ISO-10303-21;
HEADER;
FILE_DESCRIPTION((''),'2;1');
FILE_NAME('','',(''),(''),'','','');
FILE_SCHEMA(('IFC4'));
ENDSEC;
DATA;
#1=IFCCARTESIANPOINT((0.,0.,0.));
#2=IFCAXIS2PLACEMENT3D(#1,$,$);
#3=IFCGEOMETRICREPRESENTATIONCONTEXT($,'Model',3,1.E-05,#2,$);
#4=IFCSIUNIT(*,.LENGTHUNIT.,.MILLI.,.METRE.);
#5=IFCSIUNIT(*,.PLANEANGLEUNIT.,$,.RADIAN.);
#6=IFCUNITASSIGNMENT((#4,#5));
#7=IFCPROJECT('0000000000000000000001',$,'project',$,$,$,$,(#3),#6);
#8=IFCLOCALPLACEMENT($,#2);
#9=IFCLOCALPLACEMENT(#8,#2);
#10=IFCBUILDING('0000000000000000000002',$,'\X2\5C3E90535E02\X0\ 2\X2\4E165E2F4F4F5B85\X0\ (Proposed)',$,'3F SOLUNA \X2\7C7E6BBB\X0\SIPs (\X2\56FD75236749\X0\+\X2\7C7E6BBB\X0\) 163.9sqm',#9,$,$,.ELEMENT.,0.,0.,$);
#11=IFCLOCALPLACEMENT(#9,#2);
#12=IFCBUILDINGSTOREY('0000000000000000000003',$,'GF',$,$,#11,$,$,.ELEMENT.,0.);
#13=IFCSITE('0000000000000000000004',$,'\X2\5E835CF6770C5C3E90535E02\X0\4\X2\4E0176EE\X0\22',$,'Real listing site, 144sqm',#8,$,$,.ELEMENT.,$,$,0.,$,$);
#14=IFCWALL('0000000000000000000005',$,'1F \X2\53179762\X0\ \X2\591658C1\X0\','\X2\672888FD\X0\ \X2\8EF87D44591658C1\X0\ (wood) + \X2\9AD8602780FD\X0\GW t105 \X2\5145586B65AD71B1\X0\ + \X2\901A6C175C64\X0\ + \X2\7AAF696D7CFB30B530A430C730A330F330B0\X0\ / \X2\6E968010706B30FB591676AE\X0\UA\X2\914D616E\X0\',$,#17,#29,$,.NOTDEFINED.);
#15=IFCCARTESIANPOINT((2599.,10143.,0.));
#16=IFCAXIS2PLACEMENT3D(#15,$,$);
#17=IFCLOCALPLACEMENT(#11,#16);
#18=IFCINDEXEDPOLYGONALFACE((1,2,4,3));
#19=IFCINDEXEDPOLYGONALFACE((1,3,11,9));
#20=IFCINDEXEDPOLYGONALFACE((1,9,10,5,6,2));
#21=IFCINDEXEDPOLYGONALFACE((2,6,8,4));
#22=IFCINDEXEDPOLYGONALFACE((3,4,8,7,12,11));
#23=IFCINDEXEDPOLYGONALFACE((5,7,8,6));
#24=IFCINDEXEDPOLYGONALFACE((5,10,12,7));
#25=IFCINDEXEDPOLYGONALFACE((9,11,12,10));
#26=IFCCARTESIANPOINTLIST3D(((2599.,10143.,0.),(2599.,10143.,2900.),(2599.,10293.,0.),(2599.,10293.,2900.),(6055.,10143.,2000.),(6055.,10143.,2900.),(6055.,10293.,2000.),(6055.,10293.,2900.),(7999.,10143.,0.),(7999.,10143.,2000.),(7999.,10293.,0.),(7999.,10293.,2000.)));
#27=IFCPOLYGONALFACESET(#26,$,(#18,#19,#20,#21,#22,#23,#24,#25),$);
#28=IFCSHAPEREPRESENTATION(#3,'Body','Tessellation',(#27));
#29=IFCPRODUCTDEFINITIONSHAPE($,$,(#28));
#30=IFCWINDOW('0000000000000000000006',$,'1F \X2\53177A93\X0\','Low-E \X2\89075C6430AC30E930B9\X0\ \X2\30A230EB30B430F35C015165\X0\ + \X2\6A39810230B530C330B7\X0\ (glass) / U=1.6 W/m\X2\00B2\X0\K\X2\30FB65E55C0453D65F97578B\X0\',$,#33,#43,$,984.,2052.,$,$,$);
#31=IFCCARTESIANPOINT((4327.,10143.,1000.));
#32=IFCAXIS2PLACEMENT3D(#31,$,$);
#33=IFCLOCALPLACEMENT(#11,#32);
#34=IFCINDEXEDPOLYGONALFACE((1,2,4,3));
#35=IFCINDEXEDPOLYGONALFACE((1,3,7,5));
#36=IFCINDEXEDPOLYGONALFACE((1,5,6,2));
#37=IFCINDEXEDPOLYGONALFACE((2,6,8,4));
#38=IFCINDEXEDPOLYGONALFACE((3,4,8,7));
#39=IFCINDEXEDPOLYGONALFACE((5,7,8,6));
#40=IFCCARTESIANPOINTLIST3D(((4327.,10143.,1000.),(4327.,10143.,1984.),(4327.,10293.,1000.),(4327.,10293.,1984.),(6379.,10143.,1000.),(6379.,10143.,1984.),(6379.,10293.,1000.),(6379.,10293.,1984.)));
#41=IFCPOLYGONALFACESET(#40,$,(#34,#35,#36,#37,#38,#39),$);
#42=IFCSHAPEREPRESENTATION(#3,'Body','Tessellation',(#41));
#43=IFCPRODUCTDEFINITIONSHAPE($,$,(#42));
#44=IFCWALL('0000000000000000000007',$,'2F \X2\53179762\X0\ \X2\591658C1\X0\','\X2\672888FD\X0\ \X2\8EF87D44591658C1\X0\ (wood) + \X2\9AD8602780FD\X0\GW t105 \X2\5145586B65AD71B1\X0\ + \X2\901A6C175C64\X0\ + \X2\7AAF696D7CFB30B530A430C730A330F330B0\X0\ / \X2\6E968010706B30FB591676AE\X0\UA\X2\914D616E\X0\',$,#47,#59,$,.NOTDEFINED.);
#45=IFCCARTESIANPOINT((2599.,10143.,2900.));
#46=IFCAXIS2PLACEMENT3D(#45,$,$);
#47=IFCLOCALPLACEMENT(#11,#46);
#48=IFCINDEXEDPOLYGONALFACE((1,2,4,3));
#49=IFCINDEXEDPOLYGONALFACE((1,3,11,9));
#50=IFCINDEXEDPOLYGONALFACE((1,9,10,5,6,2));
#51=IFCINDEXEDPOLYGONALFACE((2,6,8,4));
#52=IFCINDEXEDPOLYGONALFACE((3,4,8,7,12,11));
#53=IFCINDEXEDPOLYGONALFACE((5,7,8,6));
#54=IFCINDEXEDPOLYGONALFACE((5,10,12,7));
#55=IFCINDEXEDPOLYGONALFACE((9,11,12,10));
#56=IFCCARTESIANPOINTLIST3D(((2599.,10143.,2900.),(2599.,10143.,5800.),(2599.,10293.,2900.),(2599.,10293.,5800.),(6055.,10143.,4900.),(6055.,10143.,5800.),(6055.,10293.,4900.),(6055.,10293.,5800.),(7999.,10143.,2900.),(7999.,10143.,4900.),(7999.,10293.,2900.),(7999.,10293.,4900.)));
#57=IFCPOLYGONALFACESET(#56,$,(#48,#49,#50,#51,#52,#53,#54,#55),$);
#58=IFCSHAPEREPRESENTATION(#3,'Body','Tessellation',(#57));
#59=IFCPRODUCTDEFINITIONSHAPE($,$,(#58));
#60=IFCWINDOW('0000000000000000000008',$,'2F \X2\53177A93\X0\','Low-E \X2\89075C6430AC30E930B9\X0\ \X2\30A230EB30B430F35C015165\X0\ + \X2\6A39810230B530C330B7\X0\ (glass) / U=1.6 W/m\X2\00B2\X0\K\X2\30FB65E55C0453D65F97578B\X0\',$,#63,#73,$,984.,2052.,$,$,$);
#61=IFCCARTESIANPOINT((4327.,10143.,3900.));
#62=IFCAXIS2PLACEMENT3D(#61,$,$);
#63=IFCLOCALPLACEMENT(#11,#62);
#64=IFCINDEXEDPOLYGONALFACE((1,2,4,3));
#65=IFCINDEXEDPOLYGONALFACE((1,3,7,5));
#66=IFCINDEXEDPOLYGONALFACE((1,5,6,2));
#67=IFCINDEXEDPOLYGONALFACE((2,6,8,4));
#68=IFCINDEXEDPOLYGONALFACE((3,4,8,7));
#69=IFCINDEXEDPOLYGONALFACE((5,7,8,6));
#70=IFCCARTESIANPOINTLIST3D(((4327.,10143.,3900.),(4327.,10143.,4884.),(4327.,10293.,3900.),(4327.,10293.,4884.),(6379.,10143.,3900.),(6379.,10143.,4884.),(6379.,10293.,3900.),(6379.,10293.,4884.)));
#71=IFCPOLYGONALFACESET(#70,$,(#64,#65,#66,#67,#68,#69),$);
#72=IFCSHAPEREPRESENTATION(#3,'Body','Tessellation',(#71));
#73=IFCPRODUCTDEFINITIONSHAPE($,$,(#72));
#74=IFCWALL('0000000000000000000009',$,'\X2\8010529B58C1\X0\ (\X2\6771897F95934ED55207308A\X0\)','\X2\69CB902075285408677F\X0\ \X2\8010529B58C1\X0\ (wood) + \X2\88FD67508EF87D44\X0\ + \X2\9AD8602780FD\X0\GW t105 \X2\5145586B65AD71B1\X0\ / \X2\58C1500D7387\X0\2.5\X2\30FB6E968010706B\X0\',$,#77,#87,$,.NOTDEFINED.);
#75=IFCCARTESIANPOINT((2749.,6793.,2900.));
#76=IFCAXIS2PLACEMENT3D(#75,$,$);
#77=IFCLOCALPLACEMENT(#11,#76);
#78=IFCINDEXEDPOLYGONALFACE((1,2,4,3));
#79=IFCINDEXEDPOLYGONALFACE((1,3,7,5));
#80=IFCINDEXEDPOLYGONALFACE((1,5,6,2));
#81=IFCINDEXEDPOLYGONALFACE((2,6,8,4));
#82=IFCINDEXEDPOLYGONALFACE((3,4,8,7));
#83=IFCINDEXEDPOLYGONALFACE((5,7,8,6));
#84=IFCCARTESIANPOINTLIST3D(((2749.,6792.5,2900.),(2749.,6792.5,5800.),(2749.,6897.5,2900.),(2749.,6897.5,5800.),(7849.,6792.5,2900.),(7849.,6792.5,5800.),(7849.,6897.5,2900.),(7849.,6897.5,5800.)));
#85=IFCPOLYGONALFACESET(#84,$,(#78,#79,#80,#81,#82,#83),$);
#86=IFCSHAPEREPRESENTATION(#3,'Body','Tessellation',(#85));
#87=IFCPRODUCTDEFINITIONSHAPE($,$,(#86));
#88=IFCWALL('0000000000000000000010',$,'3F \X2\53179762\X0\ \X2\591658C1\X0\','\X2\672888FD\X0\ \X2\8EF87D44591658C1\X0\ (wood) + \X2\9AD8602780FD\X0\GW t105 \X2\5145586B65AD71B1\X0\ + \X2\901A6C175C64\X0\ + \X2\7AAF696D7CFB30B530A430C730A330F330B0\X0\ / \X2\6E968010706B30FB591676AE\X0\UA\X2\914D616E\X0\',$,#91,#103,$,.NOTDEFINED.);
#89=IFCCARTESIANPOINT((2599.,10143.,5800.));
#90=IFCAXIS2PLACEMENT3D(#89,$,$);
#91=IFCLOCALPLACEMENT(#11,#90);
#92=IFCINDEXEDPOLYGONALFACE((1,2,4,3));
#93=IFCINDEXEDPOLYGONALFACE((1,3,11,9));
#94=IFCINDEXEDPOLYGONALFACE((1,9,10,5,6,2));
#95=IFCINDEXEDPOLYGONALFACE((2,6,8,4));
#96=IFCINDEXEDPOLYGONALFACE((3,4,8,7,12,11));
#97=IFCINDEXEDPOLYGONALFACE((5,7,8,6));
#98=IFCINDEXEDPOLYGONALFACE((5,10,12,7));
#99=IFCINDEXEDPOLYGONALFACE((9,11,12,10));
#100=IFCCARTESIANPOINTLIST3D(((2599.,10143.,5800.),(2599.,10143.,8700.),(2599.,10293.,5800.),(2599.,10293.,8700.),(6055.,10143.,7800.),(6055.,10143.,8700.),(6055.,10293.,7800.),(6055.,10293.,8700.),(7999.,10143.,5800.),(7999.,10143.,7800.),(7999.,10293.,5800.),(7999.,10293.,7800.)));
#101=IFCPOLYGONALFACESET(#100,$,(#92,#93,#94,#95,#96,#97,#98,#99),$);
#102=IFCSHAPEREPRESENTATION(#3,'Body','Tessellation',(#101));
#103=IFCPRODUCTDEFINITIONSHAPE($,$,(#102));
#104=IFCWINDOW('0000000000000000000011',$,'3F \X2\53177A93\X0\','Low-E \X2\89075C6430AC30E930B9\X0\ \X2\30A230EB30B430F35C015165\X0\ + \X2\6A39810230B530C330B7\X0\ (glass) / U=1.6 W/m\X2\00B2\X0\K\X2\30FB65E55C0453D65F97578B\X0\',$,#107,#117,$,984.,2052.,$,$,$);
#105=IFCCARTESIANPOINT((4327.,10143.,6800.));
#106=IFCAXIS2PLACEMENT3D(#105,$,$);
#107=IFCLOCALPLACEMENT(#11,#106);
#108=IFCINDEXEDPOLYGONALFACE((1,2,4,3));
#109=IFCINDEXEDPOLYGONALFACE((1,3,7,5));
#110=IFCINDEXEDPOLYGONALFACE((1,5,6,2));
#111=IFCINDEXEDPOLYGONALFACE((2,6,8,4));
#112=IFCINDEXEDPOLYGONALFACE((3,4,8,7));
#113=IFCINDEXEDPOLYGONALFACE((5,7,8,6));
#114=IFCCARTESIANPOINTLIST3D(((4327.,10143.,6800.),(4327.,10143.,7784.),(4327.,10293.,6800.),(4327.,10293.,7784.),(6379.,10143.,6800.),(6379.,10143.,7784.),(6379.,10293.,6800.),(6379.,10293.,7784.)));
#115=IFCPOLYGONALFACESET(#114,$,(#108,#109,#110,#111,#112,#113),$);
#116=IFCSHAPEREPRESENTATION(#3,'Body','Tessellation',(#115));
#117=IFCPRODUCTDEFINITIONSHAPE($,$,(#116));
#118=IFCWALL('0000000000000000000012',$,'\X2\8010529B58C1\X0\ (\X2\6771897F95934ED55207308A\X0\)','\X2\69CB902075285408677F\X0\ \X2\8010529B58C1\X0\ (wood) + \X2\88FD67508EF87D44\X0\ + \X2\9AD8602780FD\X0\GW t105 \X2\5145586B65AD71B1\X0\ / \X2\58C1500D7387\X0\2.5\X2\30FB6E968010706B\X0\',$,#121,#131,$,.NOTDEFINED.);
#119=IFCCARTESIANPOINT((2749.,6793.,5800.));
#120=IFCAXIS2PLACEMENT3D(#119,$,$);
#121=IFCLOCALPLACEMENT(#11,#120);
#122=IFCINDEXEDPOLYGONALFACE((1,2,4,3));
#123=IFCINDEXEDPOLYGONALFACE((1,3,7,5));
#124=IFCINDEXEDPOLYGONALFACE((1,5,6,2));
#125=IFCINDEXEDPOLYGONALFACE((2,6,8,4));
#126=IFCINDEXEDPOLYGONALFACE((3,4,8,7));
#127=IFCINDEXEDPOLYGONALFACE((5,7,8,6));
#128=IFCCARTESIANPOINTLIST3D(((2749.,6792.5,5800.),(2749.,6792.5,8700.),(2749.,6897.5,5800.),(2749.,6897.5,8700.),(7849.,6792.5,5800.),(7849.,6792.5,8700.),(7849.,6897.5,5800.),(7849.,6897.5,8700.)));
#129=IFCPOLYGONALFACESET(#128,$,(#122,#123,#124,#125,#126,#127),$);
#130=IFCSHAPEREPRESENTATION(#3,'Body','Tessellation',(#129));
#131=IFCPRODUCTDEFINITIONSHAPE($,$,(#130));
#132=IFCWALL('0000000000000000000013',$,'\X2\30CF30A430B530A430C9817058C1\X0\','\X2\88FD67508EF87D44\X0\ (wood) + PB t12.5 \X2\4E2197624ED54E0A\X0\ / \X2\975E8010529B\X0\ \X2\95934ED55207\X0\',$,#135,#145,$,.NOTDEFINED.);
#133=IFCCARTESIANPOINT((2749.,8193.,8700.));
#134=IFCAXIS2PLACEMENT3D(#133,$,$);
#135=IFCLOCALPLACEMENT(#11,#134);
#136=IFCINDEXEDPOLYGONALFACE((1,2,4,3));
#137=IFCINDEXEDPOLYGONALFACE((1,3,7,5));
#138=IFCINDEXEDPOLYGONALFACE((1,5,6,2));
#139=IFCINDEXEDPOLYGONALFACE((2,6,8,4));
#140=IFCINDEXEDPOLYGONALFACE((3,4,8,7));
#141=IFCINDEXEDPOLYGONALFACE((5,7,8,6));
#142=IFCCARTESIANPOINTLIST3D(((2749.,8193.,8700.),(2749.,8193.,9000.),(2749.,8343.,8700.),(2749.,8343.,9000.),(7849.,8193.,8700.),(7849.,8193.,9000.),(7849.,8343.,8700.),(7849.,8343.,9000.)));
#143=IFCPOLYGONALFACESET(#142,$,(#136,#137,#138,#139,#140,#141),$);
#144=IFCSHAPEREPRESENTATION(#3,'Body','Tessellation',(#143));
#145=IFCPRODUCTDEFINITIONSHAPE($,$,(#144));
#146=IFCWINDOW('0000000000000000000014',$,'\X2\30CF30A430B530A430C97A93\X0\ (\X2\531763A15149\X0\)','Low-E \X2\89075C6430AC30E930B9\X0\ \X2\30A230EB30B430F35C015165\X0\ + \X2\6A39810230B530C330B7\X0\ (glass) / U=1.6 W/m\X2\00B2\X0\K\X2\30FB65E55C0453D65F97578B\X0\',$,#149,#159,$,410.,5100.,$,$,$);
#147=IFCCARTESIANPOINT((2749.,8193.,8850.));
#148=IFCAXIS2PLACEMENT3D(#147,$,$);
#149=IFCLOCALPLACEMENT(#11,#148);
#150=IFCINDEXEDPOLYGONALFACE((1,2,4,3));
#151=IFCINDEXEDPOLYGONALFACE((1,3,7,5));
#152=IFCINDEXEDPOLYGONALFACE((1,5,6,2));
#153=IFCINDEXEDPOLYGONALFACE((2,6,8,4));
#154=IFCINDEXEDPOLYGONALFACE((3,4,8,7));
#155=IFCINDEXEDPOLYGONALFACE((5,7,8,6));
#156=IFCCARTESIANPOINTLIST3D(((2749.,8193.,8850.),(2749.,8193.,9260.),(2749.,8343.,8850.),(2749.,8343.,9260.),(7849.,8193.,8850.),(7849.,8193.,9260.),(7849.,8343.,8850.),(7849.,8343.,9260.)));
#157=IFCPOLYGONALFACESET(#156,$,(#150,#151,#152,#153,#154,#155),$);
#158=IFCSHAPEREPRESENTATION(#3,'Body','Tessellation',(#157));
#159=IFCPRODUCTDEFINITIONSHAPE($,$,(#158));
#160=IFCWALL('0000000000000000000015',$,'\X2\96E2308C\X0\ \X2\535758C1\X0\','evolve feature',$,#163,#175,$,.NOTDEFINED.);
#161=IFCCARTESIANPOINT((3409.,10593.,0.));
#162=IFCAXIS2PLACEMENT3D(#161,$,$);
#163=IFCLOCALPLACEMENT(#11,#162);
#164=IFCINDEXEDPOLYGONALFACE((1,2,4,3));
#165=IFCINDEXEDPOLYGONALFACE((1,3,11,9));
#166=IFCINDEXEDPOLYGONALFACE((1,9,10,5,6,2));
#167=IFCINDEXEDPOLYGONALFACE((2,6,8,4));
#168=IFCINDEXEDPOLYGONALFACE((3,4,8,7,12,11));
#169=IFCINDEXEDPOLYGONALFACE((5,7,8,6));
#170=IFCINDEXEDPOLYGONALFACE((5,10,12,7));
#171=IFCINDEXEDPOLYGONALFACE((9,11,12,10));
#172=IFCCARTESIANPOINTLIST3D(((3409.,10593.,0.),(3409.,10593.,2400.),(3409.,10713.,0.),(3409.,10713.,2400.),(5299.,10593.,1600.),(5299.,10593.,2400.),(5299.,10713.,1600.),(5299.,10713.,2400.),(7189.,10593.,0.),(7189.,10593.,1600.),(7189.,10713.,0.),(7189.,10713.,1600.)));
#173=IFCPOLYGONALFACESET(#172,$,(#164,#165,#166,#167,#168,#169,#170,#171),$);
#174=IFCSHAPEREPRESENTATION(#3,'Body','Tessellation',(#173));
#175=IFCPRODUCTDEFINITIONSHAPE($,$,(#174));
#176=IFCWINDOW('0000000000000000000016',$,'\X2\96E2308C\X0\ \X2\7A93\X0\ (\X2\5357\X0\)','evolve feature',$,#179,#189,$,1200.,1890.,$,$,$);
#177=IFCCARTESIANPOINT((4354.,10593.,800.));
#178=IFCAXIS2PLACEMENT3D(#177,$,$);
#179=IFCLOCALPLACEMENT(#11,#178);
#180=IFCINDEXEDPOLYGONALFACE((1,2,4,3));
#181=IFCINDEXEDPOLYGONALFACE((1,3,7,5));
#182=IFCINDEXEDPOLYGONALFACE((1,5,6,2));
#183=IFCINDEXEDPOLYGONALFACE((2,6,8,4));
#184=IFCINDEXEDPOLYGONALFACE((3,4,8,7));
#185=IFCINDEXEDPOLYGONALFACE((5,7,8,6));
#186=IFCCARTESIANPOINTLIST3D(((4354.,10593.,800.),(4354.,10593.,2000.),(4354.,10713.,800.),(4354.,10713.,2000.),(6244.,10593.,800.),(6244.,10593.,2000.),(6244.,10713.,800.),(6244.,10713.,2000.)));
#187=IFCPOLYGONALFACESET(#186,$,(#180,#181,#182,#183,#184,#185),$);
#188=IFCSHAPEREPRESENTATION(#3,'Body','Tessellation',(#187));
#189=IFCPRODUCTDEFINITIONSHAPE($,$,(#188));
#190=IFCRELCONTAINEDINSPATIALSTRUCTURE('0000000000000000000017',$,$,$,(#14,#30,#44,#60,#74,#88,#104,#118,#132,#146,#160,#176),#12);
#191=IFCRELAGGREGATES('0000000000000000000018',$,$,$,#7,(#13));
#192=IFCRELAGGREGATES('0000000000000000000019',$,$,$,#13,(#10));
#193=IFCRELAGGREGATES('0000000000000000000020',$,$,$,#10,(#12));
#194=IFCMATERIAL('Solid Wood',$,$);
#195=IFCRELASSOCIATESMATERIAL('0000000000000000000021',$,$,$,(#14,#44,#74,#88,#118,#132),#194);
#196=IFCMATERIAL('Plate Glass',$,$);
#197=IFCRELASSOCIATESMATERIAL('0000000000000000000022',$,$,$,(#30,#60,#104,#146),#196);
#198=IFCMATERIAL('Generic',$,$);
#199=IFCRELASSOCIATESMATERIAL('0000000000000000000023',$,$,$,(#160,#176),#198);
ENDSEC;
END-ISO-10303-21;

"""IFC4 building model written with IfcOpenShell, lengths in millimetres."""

from ifc_helpers import new_model, si_unit, frame, frame_2d, origin, place, context, project, spatial, rectangle, extrude, material, element, fill, save


model = new_model("IFC4")

# Units and contexts
model_context = context("Model", 3, precision=1e-05, world=origin())
ifc_project = project(units=[si_unit("LENGTHUNIT", "METRE", prefix="MILLI"), si_unit("PLANEANGLEUNIT", "RADIAN")], contexts=[model_context])

# Site, building, storey
site_placement = place(None, origin())
site = spatial("IfcSite", under=ifc_project, at=site_placement, Name="広島県尾道市4丁目22", ObjectType="Real listing site, 144sqm", CompositionType="ELEMENT", RefElevation=0.0)
building_placement = place(site_placement, origin())
building = spatial("IfcBuilding", under=site, at=building_placement, Name="尾道市 2世帯住宅 (Proposed)", ObjectType="3F SOLUNA 籾殻SIPs (国産杉+籾殻) 163.9sqm", CompositionType="ELEMENT", ElevationOfRefHeight=0.0, ElevationOfTerrain=0.0)
storey_placement = place(building_placement, origin())
storey = spatial("IfcBuildingStorey", under=building, at=storey_placement, Name="GF", CompositionType="ELEMENT", Elevation=0.0)

# Shared definitions
ifc_material_1 = material(Name="Generic")

# Wall, opening, window
ifc_material_2 = material(Name="Solid Wood")
wall_1_placement = place(storey_placement, frame((2599.0, 10143.0, 0.0)))
wall_1 = element("IfcWall", 1, at=wall_1_placement, inside=storey, material=ifc_material_2, Name="1F 北面 外壁", Description="木製 軸組外壁 (wood) + 高性能GW t105 充填断熱 + 通気層 + 窯業系サイディング / 準耐火・外皮UA配慮", PredefinedType="NOTDEFINED", context=model_context, shape_type="SweptSolid", body=[
    extrude(rectangle(XDim=5400.0, YDim=150.0, at=frame_2d((2700.0, 75.0))), frame((2599.0, 10143.0, 0.0)), (0.0, 0.0, 1.0), 2900.0),
])
opening_1_placement = place(storey_placement, frame((4327.0, 10143.0, 1000.0)))
opening_1 = element("IfcOpeningElement", 2, at=opening_1_placement, cuts=wall_1, PredefinedType="NOTDEFINED", context=model_context, shape_type="SweptSolid", body=[
    extrude(rectangle(XDim=2052.0, YDim=150.0, at=frame_2d((1026.0, 75.0))), frame((4327.0, 10143.0, 1000.0)), (0.0, 0.0, 1.0), 984.0),
])
ifc_material_3 = material(Name="Plate Glass")
window_1_placement = place(storey_placement, frame((4327.0, 10143.0, 1000.0)))
window_1 = element("IfcWindow", 3, at=window_1_placement, inside=storey, material=ifc_material_3, Name="1F 北窓", Description="Low-E 複層ガラス アルゴン封入 + 樹脂サッシ (glass) / U=1.6 W/m²K・日射取得型", OverallHeight=984.0, OverallWidth=2052.0, context=model_context, shape_type="SweptSolid", body=[
    extrude(rectangle(XDim=2052.0, YDim=150.0, at=frame_2d((1026.0, 75.0))), frame((4327.0, 10143.0, 1000.0)), (0.0, 0.0, 1.0), 984.0),
])
fill(opening_1, window_1)

# Wall, opening, window
wall_2_placement = place(storey_placement, frame((2599.0, 10143.0, 2900.0)))
wall_2 = element("IfcWall", 4, at=wall_2_placement, inside=storey, material=ifc_material_2, Name="2F 北面 外壁", Description="木製 軸組外壁 (wood) + 高性能GW t105 充填断熱 + 通気層 + 窯業系サイディング / 準耐火・外皮UA配慮", PredefinedType="NOTDEFINED", context=model_context, shape_type="SweptSolid", body=[
    extrude(rectangle(XDim=5400.0, YDim=150.0, at=frame_2d((2700.0, 75.0))), frame((2599.0, 10143.0, 2900.0)), (0.0, 0.0, 1.0), 2900.0),
])
opening_2_placement = place(storey_placement, frame((4327.0, 10143.0, 3900.0)))
opening_2 = element("IfcOpeningElement", 5, at=opening_2_placement, cuts=wall_2, PredefinedType="NOTDEFINED", context=model_context, shape_type="SweptSolid", body=[
    extrude(rectangle(XDim=2052.0, YDim=150.0, at=frame_2d((1026.0, 75.0))), frame((4327.0, 10143.0, 3900.0)), (0.0, 0.0, 1.0), 984.0),
])
window_2_placement = place(storey_placement, frame((4327.0, 10143.0, 3900.0)))
window_2 = element("IfcWindow", 6, at=window_2_placement, inside=storey, material=ifc_material_3, Name="2F 北窓", Description="Low-E 複層ガラス アルゴン封入 + 樹脂サッシ (glass) / U=1.6 W/m²K・日射取得型", OverallHeight=984.0, OverallWidth=2052.0, context=model_context, shape_type="SweptSolid", body=[
    extrude(rectangle(XDim=2052.0, YDim=150.0, at=frame_2d((1026.0, 75.0))), frame((4327.0, 10143.0, 3900.0)), (0.0, 0.0, 1.0), 984.0),
])
fill(opening_2, window_2)

# Wall
wall_3_placement = place(storey_placement, frame((2749.0, 6793.0, 2900.0)))
element("IfcWall", 7, at=wall_3_placement, inside=storey, material=ifc_material_2, Name="耐力壁 (東西間仕切り)", Description="構造用合板 耐力壁 (wood) + 製材軸組 + 高性能GW t105 充填断熱 / 壁倍率2.5・準耐火", PredefinedType="NOTDEFINED", context=model_context, shape_type="SweptSolid", body=[
    extrude(rectangle(XDim=5100.0, YDim=105.0, at=frame_2d((2550.0, 52.0))), frame((2749.0, 6793.0, 2900.0)), (0.0, 0.0, 1.0), 2900.0),
])

# Wall, opening, window
wall_4_placement = place(storey_placement, frame((2599.0, 10143.0, 5800.0)))
wall_4 = element("IfcWall", 8, at=wall_4_placement, inside=storey, material=ifc_material_2, Name="3F 北面 外壁", Description="木製 軸組外壁 (wood) + 高性能GW t105 充填断熱 + 通気層 + 窯業系サイディング / 準耐火・外皮UA配慮", PredefinedType="NOTDEFINED", context=model_context, shape_type="SweptSolid", body=[
    extrude(rectangle(XDim=5400.0, YDim=150.0, at=frame_2d((2700.0, 75.0))), frame((2599.0, 10143.0, 5800.0)), (0.0, 0.0, 1.0), 2900.0),
])
opening_3_placement = place(storey_placement, frame((4327.0, 10143.0, 6800.0)))
opening_3 = element("IfcOpeningElement", 9, at=opening_3_placement, cuts=wall_4, PredefinedType="NOTDEFINED", context=model_context, shape_type="SweptSolid", body=[
    extrude(rectangle(XDim=2052.0, YDim=150.0, at=frame_2d((1026.0, 75.0))), frame((4327.0, 10143.0, 6800.0)), (0.0, 0.0, 1.0), 984.0),
])
window_3_placement = place(storey_placement, frame((4327.0, 10143.0, 6800.0)))
window_3 = element("IfcWindow", 10, at=window_3_placement, inside=storey, material=ifc_material_3, Name="3F 北窓", Description="Low-E 複層ガラス アルゴン封入 + 樹脂サッシ (glass) / U=1.6 W/m²K・日射取得型", OverallHeight=984.0, OverallWidth=2052.0, context=model_context, shape_type="SweptSolid", body=[
    extrude(rectangle(XDim=2052.0, YDim=150.0, at=frame_2d((1026.0, 75.0))), frame((4327.0, 10143.0, 6800.0)), (0.0, 0.0, 1.0), 984.0),
])
fill(opening_3, window_3)

# Wall
wall_5_placement = place(storey_placement, frame((2749.0, 6793.0, 5800.0)))
element("IfcWall", 11, at=wall_5_placement, inside=storey, material=ifc_material_2, Name="耐力壁 (東西間仕切り)", Description="構造用合板 耐力壁 (wood) + 製材軸組 + 高性能GW t105 充填断熱 / 壁倍率2.5・準耐火", PredefinedType="NOTDEFINED", context=model_context, shape_type="SweptSolid", body=[
    extrude(rectangle(XDim=5100.0, YDim=105.0, at=frame_2d((2550.0, 52.0))), frame((2749.0, 6793.0, 5800.0)), (0.0, 0.0, 1.0), 2900.0),
])

# Walls, openings, windows
wall_6_placement = place(storey_placement, frame((2749.0, 8193.0, 8700.0)))
wall_6 = element("IfcWall", 12, at=wall_6_placement, inside=storey, material=ifc_material_2, Name="ハイサイド腰壁", Description="製材軸組 (wood) + PB t12.5 両面仕上 / 非耐力 間仕切", PredefinedType="NOTDEFINED", context=model_context, shape_type="SweptSolid", body=[
    extrude(rectangle(XDim=5100.0, YDim=150.0, at=frame_2d((2550.0, 75.0))), frame((2749.0, 8193.0, 8700.0)), (0.0, 0.0, 1.0), 700.0),
])
opening_4_placement = place(storey_placement, frame((2749.0, 8193.0, 8850.0)))
opening_4 = element("IfcOpeningElement", 13, at=opening_4_placement, cuts=wall_6, PredefinedType="NOTDEFINED", context=model_context, shape_type="SweptSolid", body=[
    extrude(rectangle(XDim=5100.0, YDim=150.0, at=frame_2d((2550.0, 75.0))), frame((2749.0, 8193.0, 8850.0)), (0.0, 0.0, 1.0), 410.0),
])
window_4_placement = place(storey_placement, frame((2749.0, 8193.0, 8850.0)))
window_4 = element("IfcWindow", 14, at=window_4_placement, inside=storey, material=ifc_material_3, Name="ハイサイド窓 (北採光)", Description="Low-E 複層ガラス アルゴン封入 + 樹脂サッシ (glass) / U=1.6 W/m²K・日射取得型", OverallHeight=410.0, OverallWidth=5100.0, context=model_context, shape_type="SweptSolid", body=[
    extrude(rectangle(XDim=5100.0, YDim=150.0, at=frame_2d((2550.0, 75.0))), frame((2749.0, 8193.0, 8850.0)), (0.0, 0.0, 1.0), 410.0),
])
fill(opening_4, window_4)
wall_7_placement = place(storey_placement, frame((3409.0, 10593.0, 0.0)))
wall_7 = element("IfcWall", 15, at=wall_7_placement, inside=storey, material=ifc_material_1, Name="離れ 南壁", Description="evolve feature", PredefinedType="NOTDEFINED", context=model_context, shape_type="SweptSolid", body=[
    extrude(rectangle(XDim=3780.0, YDim=120.0, at=frame_2d((1890.0, 60.0))), frame((3409.0, 10593.0, 0.0)), (0.0, 0.0, 1.0), 2400.0),
])
opening_5_placement = place(storey_placement, frame((4354.0, 10593.0, 800.0)))
opening_5 = element("IfcOpeningElement", 16, at=opening_5_placement, cuts=wall_7, PredefinedType="NOTDEFINED", context=model_context, shape_type="SweptSolid", body=[
    extrude(rectangle(XDim=1890.0, YDim=120.0, at=frame_2d((945.0, 60.0))), frame((4354.0, 10593.0, 800.0)), (0.0, 0.0, 1.0), 1200.0),
])
window_5_placement = place(storey_placement, frame((4354.0, 10593.0, 800.0)))
window_5 = element("IfcWindow", 17, at=window_5_placement, inside=storey, material=ifc_material_1, Name="離れ 窓 (南)", Description="evolve feature", OverallHeight=1200.0, OverallWidth=1890.0, context=model_context, shape_type="SweptSolid", body=[
    extrude(rectangle(XDim=1890.0, YDim=120.0, at=frame_2d((945.0, 60.0))), frame((4354.0, 10593.0, 800.0)), (0.0, 0.0, 1.0), 1200.0),
])
fill(opening_5, window_5)

save(model, "model.ifc")
